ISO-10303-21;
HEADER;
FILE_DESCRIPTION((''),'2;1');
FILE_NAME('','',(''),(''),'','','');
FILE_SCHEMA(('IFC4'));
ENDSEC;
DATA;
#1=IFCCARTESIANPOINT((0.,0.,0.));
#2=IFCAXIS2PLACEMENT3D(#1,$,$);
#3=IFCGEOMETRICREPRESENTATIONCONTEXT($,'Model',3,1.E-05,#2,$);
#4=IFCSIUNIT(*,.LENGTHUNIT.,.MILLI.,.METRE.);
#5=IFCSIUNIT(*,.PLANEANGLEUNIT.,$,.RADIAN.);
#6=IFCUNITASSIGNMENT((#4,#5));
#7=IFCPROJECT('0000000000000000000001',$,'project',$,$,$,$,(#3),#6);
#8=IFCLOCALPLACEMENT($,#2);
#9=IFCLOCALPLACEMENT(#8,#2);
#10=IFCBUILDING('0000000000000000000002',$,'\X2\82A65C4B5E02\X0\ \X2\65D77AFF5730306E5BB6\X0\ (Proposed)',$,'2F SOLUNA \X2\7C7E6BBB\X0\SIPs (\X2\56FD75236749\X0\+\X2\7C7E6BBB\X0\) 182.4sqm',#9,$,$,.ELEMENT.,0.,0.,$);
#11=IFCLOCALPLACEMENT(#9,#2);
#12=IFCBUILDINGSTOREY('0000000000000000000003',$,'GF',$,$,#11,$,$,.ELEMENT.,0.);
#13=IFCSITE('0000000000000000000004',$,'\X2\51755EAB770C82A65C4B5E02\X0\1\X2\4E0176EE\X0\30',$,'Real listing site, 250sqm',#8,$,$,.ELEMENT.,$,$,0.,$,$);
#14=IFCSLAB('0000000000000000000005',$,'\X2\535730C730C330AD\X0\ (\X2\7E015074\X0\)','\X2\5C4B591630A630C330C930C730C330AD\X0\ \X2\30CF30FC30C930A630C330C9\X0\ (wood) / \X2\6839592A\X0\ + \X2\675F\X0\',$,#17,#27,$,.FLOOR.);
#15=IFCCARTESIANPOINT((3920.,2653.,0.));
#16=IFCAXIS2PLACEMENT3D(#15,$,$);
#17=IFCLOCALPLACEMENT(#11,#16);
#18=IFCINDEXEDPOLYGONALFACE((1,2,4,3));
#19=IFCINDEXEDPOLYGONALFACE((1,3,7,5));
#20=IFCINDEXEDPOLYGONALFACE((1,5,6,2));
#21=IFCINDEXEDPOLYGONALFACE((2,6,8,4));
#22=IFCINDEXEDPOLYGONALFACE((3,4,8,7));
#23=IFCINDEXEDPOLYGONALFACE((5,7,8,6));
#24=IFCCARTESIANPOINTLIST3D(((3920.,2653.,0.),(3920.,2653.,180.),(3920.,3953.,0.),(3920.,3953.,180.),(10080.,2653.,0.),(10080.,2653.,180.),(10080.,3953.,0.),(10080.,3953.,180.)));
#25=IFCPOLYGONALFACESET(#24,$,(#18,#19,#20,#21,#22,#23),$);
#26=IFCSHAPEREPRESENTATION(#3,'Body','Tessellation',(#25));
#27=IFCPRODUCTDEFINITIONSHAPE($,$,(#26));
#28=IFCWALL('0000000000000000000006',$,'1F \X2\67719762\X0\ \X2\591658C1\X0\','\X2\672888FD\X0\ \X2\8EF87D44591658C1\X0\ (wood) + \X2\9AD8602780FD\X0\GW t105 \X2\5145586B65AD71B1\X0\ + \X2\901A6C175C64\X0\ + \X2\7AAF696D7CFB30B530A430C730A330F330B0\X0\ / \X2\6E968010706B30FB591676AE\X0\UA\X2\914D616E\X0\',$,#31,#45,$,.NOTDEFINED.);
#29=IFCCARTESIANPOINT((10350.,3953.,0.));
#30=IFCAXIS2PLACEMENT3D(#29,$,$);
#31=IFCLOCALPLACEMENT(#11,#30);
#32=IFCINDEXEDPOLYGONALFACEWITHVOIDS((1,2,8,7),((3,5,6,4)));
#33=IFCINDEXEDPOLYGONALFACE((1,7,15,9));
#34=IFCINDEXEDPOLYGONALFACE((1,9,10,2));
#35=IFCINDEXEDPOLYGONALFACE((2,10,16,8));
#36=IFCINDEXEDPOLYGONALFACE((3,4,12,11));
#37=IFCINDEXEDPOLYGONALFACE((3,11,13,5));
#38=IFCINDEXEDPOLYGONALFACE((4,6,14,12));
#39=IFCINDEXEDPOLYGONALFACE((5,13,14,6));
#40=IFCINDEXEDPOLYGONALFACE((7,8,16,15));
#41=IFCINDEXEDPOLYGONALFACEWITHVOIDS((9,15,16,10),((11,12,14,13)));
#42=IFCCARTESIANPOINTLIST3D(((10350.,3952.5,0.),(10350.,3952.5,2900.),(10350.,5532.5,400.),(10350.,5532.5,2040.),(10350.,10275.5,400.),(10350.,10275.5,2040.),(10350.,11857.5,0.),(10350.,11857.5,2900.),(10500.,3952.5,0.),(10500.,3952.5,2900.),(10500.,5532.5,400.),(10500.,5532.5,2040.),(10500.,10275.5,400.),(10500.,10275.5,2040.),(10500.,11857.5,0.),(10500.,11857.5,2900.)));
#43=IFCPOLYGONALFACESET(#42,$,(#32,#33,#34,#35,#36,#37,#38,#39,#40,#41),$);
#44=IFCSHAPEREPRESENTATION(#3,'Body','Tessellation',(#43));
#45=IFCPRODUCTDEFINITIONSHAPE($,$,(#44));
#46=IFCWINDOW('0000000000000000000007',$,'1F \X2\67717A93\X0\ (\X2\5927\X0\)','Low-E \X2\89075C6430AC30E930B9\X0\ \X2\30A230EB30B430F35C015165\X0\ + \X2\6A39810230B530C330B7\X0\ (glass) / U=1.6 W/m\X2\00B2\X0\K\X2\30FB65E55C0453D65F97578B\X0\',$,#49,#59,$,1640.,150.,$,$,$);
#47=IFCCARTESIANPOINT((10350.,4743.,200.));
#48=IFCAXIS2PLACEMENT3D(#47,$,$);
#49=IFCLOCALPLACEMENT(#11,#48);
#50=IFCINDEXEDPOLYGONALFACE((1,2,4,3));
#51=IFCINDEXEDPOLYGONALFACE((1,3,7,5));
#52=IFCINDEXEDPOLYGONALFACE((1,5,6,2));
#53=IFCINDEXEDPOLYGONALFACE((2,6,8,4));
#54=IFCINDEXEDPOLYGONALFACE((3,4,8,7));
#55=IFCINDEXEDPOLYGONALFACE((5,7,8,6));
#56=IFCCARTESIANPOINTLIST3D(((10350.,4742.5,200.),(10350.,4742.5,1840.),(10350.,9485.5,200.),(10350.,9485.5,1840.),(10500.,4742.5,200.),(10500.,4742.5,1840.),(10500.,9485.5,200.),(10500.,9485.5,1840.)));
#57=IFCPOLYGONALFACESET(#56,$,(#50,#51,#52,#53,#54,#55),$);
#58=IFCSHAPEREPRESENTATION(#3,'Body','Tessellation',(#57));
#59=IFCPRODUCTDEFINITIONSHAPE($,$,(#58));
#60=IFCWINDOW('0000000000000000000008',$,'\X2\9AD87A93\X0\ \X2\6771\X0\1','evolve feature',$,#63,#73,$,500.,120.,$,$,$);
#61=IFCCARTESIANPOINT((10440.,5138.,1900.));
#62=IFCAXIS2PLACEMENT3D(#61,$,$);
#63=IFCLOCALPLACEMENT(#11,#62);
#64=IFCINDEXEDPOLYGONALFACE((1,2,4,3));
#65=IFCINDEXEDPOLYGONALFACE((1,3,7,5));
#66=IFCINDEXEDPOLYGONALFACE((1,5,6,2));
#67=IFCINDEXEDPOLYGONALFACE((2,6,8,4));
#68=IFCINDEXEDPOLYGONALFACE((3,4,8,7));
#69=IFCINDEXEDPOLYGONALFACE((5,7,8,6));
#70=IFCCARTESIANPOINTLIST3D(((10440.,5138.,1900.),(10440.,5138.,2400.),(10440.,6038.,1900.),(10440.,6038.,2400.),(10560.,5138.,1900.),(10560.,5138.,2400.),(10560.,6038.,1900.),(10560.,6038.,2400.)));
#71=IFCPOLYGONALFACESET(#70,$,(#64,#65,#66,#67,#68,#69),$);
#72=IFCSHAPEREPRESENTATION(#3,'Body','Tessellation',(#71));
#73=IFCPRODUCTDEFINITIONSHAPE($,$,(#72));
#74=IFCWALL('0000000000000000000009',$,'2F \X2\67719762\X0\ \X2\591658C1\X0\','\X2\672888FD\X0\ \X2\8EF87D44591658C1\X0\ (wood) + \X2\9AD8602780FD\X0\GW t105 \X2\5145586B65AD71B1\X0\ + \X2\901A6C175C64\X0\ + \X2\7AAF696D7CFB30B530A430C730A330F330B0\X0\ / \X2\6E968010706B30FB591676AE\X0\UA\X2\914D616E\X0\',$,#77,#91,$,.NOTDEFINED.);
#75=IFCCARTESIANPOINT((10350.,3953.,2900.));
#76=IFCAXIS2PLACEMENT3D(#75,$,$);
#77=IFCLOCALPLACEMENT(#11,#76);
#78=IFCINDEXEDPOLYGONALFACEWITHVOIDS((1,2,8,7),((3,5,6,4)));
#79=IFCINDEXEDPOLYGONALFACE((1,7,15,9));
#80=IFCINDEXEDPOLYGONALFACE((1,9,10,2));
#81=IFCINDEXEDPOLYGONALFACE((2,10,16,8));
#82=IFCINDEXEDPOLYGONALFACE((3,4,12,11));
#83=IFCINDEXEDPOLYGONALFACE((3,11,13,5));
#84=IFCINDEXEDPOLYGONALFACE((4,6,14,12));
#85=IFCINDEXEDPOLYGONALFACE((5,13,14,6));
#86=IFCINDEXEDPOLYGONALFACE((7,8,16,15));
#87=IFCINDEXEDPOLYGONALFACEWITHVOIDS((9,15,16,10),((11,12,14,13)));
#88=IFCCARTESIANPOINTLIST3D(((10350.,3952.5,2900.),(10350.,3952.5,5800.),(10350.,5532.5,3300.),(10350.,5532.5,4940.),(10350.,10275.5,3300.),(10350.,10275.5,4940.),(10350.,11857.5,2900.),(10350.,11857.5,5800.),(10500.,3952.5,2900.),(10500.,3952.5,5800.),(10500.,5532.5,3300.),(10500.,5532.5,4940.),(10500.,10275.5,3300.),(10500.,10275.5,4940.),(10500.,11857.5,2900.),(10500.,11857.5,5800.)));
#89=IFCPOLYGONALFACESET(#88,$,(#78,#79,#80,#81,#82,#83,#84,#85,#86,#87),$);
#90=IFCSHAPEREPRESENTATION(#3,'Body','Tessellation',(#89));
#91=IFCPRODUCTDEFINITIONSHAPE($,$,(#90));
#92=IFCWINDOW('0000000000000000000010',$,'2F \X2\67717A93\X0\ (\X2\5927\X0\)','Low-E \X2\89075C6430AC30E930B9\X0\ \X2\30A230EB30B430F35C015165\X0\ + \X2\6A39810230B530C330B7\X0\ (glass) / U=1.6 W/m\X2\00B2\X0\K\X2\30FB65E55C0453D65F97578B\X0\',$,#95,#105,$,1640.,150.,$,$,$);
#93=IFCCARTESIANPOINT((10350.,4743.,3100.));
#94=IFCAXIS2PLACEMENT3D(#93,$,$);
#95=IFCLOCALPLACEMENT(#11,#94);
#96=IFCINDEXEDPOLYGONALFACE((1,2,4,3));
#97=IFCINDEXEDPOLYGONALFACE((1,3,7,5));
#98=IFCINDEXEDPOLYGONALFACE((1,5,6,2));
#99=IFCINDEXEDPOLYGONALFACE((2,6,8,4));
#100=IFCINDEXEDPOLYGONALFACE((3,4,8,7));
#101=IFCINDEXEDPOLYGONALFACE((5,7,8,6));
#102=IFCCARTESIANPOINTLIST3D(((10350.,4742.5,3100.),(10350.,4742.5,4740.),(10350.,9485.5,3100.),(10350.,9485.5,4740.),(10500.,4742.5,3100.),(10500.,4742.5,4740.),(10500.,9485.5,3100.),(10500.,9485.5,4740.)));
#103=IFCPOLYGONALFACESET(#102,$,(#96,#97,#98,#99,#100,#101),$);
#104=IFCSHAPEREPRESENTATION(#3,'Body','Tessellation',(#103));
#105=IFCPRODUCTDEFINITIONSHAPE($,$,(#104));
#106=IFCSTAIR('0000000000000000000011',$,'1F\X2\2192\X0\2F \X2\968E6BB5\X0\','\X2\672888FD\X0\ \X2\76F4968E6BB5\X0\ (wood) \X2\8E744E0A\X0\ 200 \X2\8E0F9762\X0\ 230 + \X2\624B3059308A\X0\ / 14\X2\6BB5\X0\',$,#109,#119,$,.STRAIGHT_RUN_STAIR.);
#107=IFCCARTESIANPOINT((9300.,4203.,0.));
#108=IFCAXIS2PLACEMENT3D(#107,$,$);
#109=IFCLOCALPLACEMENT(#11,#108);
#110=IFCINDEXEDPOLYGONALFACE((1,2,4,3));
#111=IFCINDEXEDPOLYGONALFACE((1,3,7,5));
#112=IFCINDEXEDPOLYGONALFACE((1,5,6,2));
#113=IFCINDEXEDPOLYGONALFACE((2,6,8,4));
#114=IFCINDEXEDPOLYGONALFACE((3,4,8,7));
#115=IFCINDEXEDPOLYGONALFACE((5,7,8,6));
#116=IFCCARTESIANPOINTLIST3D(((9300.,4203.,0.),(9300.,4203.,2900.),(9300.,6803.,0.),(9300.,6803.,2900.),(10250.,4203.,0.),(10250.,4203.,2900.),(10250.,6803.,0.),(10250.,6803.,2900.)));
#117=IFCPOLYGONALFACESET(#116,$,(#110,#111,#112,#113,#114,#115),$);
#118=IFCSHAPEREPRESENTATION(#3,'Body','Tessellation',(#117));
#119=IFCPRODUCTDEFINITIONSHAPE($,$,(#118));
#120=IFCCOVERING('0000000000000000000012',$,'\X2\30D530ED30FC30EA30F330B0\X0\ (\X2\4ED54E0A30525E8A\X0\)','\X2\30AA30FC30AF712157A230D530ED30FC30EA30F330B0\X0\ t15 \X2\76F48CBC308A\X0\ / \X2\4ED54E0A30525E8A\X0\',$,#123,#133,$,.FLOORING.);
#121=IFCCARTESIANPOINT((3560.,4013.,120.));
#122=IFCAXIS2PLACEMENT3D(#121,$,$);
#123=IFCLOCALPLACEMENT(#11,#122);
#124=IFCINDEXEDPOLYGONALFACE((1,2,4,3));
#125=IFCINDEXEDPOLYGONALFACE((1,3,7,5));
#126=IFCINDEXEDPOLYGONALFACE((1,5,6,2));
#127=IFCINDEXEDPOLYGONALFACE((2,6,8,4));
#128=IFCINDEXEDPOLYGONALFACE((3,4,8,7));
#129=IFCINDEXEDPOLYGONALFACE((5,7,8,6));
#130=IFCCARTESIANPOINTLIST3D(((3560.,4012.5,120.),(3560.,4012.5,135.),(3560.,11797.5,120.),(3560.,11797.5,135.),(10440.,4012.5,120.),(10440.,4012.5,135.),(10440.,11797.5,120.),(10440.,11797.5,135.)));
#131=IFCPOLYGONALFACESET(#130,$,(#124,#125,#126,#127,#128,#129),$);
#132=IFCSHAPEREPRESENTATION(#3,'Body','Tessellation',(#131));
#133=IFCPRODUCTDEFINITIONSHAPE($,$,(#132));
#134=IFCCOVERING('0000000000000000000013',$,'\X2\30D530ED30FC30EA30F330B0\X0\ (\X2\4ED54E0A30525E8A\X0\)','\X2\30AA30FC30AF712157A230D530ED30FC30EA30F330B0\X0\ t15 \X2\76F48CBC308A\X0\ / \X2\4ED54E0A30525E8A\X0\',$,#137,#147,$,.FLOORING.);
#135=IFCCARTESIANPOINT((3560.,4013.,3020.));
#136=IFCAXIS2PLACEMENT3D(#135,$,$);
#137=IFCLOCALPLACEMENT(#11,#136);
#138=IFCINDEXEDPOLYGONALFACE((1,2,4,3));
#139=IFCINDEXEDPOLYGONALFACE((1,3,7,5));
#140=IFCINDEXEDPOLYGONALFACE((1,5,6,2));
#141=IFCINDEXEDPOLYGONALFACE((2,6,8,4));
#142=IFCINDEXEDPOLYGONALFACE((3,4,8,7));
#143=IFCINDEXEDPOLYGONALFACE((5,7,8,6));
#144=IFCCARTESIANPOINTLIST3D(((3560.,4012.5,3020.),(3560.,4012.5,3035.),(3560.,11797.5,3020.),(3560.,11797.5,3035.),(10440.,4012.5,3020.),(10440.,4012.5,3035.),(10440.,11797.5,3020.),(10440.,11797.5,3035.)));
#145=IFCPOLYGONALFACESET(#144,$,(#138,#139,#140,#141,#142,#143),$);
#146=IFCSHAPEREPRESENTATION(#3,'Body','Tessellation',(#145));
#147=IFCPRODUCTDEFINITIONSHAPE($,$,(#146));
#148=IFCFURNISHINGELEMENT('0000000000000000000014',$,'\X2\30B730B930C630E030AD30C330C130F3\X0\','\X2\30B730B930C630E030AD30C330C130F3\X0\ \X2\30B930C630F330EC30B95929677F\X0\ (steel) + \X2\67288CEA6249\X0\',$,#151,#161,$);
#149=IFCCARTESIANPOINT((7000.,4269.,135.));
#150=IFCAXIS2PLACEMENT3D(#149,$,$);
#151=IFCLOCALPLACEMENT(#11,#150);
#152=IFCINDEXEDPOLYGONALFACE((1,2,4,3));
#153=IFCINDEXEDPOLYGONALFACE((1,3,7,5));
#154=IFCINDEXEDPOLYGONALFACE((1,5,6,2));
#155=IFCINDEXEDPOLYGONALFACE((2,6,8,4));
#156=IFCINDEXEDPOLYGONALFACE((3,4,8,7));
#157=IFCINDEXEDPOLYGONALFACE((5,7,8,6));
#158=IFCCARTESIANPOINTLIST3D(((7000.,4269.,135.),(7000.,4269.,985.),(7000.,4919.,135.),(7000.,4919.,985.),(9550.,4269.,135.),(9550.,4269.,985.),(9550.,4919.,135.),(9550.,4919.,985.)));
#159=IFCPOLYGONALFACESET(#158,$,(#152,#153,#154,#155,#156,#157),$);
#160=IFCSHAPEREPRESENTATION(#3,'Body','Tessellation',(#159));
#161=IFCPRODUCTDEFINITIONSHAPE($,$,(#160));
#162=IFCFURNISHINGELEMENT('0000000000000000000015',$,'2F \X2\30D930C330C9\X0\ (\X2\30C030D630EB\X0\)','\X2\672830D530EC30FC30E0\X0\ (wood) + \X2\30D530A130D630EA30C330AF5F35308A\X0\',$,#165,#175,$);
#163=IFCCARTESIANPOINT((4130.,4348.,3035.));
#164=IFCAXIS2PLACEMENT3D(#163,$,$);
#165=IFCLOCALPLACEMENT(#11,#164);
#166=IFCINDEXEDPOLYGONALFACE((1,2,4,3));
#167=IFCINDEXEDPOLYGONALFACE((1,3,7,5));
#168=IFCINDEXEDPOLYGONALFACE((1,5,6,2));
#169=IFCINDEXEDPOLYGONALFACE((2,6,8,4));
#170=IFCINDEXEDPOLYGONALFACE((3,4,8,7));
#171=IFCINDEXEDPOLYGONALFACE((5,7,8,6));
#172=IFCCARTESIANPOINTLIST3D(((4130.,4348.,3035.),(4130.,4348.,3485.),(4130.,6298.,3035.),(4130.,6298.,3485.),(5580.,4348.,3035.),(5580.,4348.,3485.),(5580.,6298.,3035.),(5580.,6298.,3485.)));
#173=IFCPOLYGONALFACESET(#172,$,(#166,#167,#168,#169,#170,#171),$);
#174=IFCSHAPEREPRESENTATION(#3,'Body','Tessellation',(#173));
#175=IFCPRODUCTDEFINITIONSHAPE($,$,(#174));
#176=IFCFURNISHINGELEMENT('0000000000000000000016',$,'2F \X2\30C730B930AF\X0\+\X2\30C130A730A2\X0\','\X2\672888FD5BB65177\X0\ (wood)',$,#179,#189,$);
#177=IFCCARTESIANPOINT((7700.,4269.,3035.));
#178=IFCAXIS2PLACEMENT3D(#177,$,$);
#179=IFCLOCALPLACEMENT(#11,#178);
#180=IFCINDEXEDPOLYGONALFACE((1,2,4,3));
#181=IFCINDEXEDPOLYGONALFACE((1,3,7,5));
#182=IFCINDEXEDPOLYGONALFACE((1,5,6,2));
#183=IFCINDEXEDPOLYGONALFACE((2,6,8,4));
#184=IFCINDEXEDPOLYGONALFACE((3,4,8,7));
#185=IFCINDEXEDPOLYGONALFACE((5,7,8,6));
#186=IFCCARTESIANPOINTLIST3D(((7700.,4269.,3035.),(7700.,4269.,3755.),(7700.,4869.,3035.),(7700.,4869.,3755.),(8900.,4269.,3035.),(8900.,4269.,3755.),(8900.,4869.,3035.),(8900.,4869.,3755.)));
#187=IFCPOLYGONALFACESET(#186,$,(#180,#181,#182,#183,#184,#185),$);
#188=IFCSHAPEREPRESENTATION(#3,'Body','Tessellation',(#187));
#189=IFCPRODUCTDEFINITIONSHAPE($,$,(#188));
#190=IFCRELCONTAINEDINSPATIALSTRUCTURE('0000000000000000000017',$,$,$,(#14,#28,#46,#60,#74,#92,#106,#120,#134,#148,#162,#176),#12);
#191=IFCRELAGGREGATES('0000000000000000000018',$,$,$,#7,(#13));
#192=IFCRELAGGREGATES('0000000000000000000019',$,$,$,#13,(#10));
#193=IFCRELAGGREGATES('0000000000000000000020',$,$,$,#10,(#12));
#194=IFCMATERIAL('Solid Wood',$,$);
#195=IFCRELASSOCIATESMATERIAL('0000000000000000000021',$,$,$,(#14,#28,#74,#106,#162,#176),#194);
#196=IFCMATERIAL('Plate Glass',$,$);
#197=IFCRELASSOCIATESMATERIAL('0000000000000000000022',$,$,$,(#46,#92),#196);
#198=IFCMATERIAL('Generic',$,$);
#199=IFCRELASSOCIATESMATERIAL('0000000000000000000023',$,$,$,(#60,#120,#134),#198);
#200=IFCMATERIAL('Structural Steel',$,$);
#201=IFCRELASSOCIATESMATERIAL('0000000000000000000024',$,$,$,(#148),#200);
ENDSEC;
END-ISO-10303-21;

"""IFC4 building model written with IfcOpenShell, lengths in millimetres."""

from ifc_helpers import new_model, si_unit, frame, frame_2d, origin, place, context, project, spatial, rectangle, extrude, material, element, fill, save


model = new_model("IFC4")

# Units and contexts
model_context = context("Model", 3, precision=1e-05, world=origin())
ifc_project = project(units=[si_unit("LENGTHUNIT", "METRE", prefix="MILLI"), si_unit("PLANEANGLEUNIT", "RADIAN")], contexts=[model_context])

# Site, building, storey
site_placement = place(None, origin())
site = spatial("IfcSite", under=ifc_project, at=site_placement, Name="兵庫県芦屋市1丁目30", ObjectType="Real listing site, 250sqm", CompositionType="ELEMENT", RefElevation=0.0)
building_placement = place(site_placement, origin())
building = spatial("IfcBuilding", under=site, at=building_placement, Name="芦屋市 旗竿地の家 (Proposed)", ObjectType="2F SOLUNA 籾殻SIPs (国産杉+籾殻) 182.4sqm", CompositionType="ELEMENT", ElevationOfRefHeight=0.0, ElevationOfTerrain=0.0)
storey_placement = place(building_placement, origin())
storey = spatial("IfcBuildingStorey", under=building, at=storey_placement, Name="GF", CompositionType="ELEMENT", Elevation=0.0)

# Slab
ifc_material_1 = material(Name="Solid Wood")
slab_placement = place(storey_placement, frame((3920.0, 2653.0, 0.0)))
element("IfcSlab", 1, at=slab_placement, inside=storey, material=ifc_material_1, Name="南デッキ (縁側)", Description="屋外ウッドデッキ ハードウッド (wood) / 根太 + 束", PredefinedType="FLOOR", context=model_context, shape_type="SweptSolid", body=[
    extrude(rectangle(XDim=6160.0, YDim=1300.0, at=frame_2d((3080.0, 650.0))), frame((3920.0, 2653.0, 0.0)), (0.0, 0.0, 1.0), 180.0),
])

# Wall, openings, windows
wall_1_placement = place(storey_placement, frame((10350.0, 3953.0, 0.0)))
wall_1 = element("IfcWall", 2, at=wall_1_placement, inside=storey, material=ifc_material_1, Name="1F 東面 外壁", Description="木製 軸組外壁 (wood) + 高性能GW t105 充填断熱 + 通気層 + 窯業系サイディング / 準耐火・外皮UA配慮", PredefinedType="NOTDEFINED", context=model_context, shape_type="SweptSolid", body=[
    extrude(rectangle(XDim=150.0, YDim=7905.0, at=frame_2d((75.0, 3952.0))), frame((10350.0, 3953.0, 0.0)), (0.0, 0.0, 1.0), 2900.0),
])
opening_1_placement = place(storey_placement, frame((10350.0, 4743.0, 200.0)))
opening_1 = element("IfcOpeningElement", 3, at=opening_1_placement, cuts=wall_1, PredefinedType="NOTDEFINED", context=model_context, shape_type="SweptSolid", body=[
    extrude(rectangle(XDim=150.0, YDim=4743.0, at=frame_2d((75.0, 2371.0))), frame((10350.0, 4743.0, 200.0)), (0.0, 0.0, 1.0), 1640.0),
])
opening_2_placement = place(storey_placement, frame((10440.0, 5138.0, 1900.0)))
opening_2 = element("IfcOpeningElement", 4, at=opening_2_placement, cuts=wall_1, PredefinedType="NOTDEFINED", context=model_context, shape_type="SweptSolid", body=[
    extrude(rectangle(XDim=120.0, YDim=900.0, at=frame_2d((60.0, 450.0))), frame((10440.0, 5138.0, 1900.0)), (0.0, 0.0, 1.0), 500.0),
])
ifc_material_2 = material(Name="Plate Glass")
window_1_placement = place(storey_placement, frame((10350.0, 4743.0, 200.0)))
window_1 = element("IfcWindow", 5, at=window_1_placement, inside=storey, material=ifc_material_2, Name="1F 東窓 (大)", Description="Low-E 複層ガラス アルゴン封入 + 樹脂サッシ (glass) / U=1.6 W/m²K・日射取得型", OverallHeight=1640.0, OverallWidth=150.0, context=model_context, shape_type="SweptSolid", body=[
    extrude(rectangle(XDim=150.0, YDim=4743.0, at=frame_2d((75.0, 2371.0))), frame((10350.0, 4743.0, 200.0)), (0.0, 0.0, 1.0), 1640.0),
])
fill(opening_1, window_1)
ifc_material_3 = material(Name="Generic")
window_2_placement = place(storey_placement, frame((10440.0, 5138.0, 1900.0)))
window_2 = element("IfcWindow", 6, at=window_2_placement, inside=storey, material=ifc_material_3, Name="高窓 東1", Description="evolve feature", OverallHeight=500.0, OverallWidth=120.0, context=model_context, shape_type="SweptSolid", body=[
    extrude(rectangle(XDim=120.0, YDim=900.0, at=frame_2d((60.0, 450.0))), frame((10440.0, 5138.0, 1900.0)), (0.0, 0.0, 1.0), 500.0),
])
fill(opening_2, window_2)

# Wall, opening, window
wall_2_placement = place(storey_placement, frame((10350.0, 3953.0, 2900.0)))
wall_2 = element("IfcWall", 7, at=wall_2_placement, inside=storey, material=ifc_material_1, Name="2F 東面 外壁", Description="木製 軸組外壁 (wood) + 高性能GW t105 充填断熱 + 通気層 + 窯業系サイディング / 準耐火・外皮UA配慮", PredefinedType="NOTDEFINED", context=model_context, shape_type="SweptSolid", body=[
    extrude(rectangle(XDim=150.0, YDim=7905.0, at=frame_2d((75.0, 3952.0))), frame((10350.0, 3953.0, 2900.0)), (0.0, 0.0, 1.0), 2900.0),
])
opening_3_placement = place(storey_placement, frame((10350.0, 4743.0, 3100.0)))
opening_3 = element("IfcOpeningElement", 8, at=opening_3_placement, cuts=wall_2, PredefinedType="NOTDEFINED", context=model_context, shape_type="SweptSolid", body=[
    extrude(rectangle(XDim=150.0, YDim=4743.0, at=frame_2d((75.0, 2371.0))), frame((10350.0, 4743.0, 3100.0)), (0.0, 0.0, 1.0), 1640.0),
])
window_3_placement = place(storey_placement, frame((10350.0, 4743.0, 3100.0)))
window_3 = element("IfcWindow", 9, at=window_3_placement, inside=storey, material=ifc_material_2, Name="2F 東窓 (大)", Description="Low-E 複層ガラス アルゴン封入 + 樹脂サッシ (glass) / U=1.6 W/m²K・日射取得型", OverallHeight=1640.0, OverallWidth=150.0, context=model_context, shape_type="SweptSolid", body=[
    extrude(rectangle(XDim=150.0, YDim=4743.0, at=frame_2d((75.0, 2371.0))), frame((10350.0, 4743.0, 3100.0)), (0.0, 0.0, 1.0), 1640.0),
])
fill(opening_3, window_3)

# Stair
stair_placement = place(storey_placement, frame((9300.0, 4203.0, 0.0)))
element("IfcStair", 10, at=stair_placement, inside=storey, material=ifc_material_1, Name="1F→2F 階段", Description="木製 直階段 (wood) 蹴上 200 踏面 230 + 手すり / 14段", PredefinedType="STRAIGHT_RUN_STAIR", context=model_context, shape_type="SweptSolid", body=[
    extrude(rectangle(XDim=950.0, YDim=2600.0, at=frame_2d((475.0, 1300.0))), frame((9300.0, 4203.0, 0.0)), (0.0, 0.0, 1.0), 2900.0),
])

# Coverings
covering_1_placement = place(storey_placement, frame((3560.0, 4013.0, 120.0)))
element("IfcCovering", 11, at=covering_1_placement, inside=storey, material=ifc_material_3, Name="フローリング (仕上げ床)", Description="オーク無垢フローリング t15 直貼り / 仕上げ床", PredefinedType="FLOORING", context=model_context, shape_type="SweptSolid", body=[
    extrude(rectangle(XDim=6880.0, YDim=7785.0, at=frame_2d((3440.0, 3892.0))), frame((3560.0, 4013.0, 120.0)), (0.0, 0.0, 1.0), 15.0),
])
covering_2_placement = place(storey_placement, frame((3560.0, 4013.0, 3020.0)))
element("IfcCovering", 12, at=covering_2_placement, inside=storey, material=ifc_material_3, Name="フローリング (仕上げ床)", Description="オーク無垢フローリング t15 直貼り / 仕上げ床", PredefinedType="FLOORING", context=model_context, shape_type="SweptSolid", body=[
    extrude(rectangle(XDim=6880.0, YDim=7785.0, at=frame_2d((3440.0, 3892.0))), frame((3560.0, 4013.0, 3020.0)), (0.0, 0.0, 1.0), 15.0),
])

# Furnishing elements
ifc_material_4 = material(Name="Structural Steel")
furnishing_1_placement = place(storey_placement, frame((7000.0, 4269.0, 135.0)))
element("IfcFurnishingElement", 13, at=furnishing_1_placement, inside=storey, material=ifc_material_4, Name="システムキッチン", Description="システムキッチン ステンレス天板 (steel) + 木質扉", context=model_context, shape_type="SweptSolid", body=[
    extrude(rectangle(XDim=2550.0, YDim=650.0, at=frame_2d((1275.0, 325.0))), frame((7000.0, 4269.0, 135.0)), (0.0, 0.0, 1.0), 850.0),
])
furnishing_2_placement = place(storey_placement, frame((4130.0, 4348.0, 3035.0)))
element("IfcFurnishingElement", 14, at=furnishing_2_placement, inside=storey, material=ifc_material_1, Name="2F ベッド (ダブル)", Description="木フレーム (wood) + ファブリック張り", context=model_context, shape_type="SweptSolid", body=[
    extrude(rectangle(XDim=1450.0, YDim=1950.0, at=frame_2d((725.0, 975.0))), frame((4130.0, 4348.0, 3035.0)), (0.0, 0.0, 1.0), 450.0),
])
furnishing_3_placement = place(storey_placement, frame((7700.0, 4269.0, 3035.0)))
element("IfcFurnishingElement", 15, at=furnishing_3_placement, inside=storey, material=ifc_material_1, Name="2F デスク+チェア", Description="木製家具 (wood)", context=model_context, shape_type="SweptSolid", body=[
    extrude(rectangle(XDim=1200.0, YDim=600.0, at=frame_2d((600.0, 300.0))), frame((7700.0, 4269.0, 3035.0)), (0.0, 0.0, 1.0), 720.0),
])

save(model, "model.ifc")
